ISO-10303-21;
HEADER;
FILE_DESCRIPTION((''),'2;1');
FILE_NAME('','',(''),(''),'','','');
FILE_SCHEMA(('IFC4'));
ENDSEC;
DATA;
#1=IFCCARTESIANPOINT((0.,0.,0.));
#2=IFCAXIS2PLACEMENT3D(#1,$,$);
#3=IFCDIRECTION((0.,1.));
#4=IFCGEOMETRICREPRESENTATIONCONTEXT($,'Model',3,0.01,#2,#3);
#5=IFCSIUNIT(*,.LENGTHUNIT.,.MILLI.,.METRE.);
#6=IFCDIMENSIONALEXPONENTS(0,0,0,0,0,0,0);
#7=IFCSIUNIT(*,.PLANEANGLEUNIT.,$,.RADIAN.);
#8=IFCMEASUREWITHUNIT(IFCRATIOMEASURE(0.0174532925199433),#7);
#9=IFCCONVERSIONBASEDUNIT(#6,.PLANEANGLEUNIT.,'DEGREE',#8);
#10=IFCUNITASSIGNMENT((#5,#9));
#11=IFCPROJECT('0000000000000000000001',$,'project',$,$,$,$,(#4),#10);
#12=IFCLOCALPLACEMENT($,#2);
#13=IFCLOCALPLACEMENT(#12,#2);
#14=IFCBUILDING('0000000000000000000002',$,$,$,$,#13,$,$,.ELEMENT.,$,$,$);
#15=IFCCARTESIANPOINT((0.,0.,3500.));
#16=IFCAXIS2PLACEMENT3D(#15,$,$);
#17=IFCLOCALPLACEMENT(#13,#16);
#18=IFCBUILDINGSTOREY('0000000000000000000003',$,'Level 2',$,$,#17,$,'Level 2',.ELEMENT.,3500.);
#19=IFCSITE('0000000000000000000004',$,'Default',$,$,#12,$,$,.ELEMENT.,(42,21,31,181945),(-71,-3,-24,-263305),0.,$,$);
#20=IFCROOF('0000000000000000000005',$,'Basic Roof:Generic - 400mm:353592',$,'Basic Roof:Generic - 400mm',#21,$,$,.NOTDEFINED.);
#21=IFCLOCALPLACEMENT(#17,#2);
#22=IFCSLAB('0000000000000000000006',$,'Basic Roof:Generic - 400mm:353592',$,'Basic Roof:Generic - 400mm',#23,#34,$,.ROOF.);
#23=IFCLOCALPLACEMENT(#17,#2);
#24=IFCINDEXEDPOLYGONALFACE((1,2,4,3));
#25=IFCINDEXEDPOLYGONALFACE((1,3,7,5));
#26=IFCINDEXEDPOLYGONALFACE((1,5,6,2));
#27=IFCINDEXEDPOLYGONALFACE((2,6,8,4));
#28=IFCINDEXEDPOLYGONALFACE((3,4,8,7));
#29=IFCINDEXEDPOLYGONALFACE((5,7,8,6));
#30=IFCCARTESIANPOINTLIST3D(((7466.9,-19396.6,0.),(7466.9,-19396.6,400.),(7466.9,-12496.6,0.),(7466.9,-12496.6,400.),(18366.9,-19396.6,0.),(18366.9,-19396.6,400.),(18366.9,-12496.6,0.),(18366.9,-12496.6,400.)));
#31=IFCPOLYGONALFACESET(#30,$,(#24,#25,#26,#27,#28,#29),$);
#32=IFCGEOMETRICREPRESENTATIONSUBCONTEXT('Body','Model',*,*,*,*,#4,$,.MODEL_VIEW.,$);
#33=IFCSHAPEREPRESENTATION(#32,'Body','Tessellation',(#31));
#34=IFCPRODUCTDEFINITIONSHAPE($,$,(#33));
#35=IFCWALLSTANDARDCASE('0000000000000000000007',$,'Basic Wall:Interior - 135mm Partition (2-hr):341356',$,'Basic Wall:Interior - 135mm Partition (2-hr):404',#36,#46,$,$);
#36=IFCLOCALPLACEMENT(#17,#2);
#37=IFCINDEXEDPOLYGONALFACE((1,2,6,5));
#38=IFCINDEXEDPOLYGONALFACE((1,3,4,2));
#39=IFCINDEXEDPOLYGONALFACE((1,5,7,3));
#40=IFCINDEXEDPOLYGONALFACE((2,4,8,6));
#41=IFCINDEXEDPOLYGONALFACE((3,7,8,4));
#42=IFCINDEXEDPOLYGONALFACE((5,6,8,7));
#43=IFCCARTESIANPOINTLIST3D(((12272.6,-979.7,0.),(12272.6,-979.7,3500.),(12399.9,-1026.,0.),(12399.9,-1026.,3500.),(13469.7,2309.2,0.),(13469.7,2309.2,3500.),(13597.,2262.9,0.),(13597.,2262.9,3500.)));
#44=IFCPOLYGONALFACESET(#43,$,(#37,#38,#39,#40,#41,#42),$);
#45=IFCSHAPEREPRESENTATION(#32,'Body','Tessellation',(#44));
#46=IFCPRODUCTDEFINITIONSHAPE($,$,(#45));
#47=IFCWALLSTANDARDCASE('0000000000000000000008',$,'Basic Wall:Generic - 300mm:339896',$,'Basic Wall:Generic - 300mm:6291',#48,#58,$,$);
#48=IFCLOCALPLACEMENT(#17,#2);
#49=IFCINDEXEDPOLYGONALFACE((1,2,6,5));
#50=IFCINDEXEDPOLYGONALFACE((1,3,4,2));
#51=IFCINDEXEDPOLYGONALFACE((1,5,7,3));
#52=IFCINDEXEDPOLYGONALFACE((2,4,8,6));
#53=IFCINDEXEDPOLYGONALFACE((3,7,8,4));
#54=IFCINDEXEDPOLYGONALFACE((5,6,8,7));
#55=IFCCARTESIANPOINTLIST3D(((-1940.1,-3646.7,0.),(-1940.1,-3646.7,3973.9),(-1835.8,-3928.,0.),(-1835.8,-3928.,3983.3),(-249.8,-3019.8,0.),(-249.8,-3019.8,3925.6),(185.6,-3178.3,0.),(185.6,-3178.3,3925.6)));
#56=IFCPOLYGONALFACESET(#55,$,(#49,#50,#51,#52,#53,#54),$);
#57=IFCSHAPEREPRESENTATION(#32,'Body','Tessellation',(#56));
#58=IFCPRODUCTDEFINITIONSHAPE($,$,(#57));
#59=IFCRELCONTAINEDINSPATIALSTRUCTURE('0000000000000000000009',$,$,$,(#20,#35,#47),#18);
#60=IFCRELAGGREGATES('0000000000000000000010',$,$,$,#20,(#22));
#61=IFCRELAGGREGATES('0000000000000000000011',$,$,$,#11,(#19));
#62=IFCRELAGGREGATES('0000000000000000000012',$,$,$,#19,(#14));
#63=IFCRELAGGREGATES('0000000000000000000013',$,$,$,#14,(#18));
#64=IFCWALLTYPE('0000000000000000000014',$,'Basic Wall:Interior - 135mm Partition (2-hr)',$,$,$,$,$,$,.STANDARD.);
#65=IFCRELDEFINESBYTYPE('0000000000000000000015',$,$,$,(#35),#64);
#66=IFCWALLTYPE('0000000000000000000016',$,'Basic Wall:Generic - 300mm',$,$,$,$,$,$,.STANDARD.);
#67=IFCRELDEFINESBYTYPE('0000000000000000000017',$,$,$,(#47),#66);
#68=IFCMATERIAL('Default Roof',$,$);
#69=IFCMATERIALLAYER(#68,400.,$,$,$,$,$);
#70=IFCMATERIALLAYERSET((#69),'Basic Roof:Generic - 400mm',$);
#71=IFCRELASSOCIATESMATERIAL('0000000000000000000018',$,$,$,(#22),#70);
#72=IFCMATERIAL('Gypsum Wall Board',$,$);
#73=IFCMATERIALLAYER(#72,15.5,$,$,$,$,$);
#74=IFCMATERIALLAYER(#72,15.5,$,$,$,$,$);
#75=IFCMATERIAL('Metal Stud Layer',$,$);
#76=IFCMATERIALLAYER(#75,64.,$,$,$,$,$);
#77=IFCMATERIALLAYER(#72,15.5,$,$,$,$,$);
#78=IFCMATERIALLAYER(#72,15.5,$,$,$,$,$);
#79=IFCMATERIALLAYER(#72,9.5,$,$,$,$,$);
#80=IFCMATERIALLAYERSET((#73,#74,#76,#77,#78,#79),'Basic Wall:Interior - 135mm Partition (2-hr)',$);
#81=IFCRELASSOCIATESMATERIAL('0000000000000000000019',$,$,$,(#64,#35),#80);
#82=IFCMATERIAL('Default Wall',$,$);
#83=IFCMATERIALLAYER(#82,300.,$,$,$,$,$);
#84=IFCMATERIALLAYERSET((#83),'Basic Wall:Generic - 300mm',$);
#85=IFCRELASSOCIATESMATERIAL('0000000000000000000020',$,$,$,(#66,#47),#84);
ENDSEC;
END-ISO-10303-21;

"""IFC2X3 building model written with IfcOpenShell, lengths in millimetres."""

from ifc_helpers import new_model, entity, si_unit, converted_unit, direction, frame, frame_2d, origin, place, context, subcontext, project, spatial, polyline, rectangle, outline, extrude, clip, bounded_halfspace, material, layer, layer_set, layer_usage, type_object, element, aggregate, save


model = new_model("IFC2X3")

# Units and contexts
model_context = context("Model", 3, precision=0.01, world=origin(), true_north=direction((0.0, 1.0)))
body_context = subcontext(model_context, "Body", "Model", "MODEL_VIEW")
ifc_project = project(units=[si_unit("LENGTHUNIT", "METRE", prefix="MILLI"), converted_unit("PLANEANGLEUNIT", "DEGREE", entity("IfcRatioMeasure", 0.0174532925199433), si_unit("PLANEANGLEUNIT", "RADIAN"), dimensions=[0, 0, 0, 0, 0, 0, 0])], contexts=[model_context])

# Site, building, storey
site_placement = place(None, origin())
site = spatial("IfcSite", under=ifc_project, at=site_placement, Name="Default", CompositionType="ELEMENT", RefLatitude=(42, 21, 31, 181945), RefLongitude=(-71, -3, -24, -263305), RefElevation=0.0)
building_placement = place(site_placement, origin())
building = spatial("IfcBuilding", under=site, at=building_placement, CompositionType="ELEMENT")
storey_placement = place(building_placement, frame((0.0, 0.0, 3500.0)))
storey = spatial("IfcBuildingStorey", under=building, at=storey_placement, Name="Level 2", LongName="Level 2", CompositionType="ELEMENT", Elevation=3500.0)

# Roof, slab
roof_placement = place(storey_placement, frame((7466.9, -19396.6, 0.0)))
roof = element("IfcRoof", 1, at=roof_placement, inside=storey, Name="Basic Roof:Generic - 400mm:353592", ObjectType="Basic Roof:Generic - 400mm", ShapeType="NOTDEFINED")
ifc_material_1 = material(Name="Default Roof")
ifc_layer_1 = layer(ifc_material_1, 400.0)
ifc_layer_set_1 = layer_set([ifc_layer_1], Name="Basic Roof:Generic - 400mm")
slab_placement = place(roof_placement, origin())
slab = element("IfcSlab", 2, at=slab_placement, material=ifc_layer_set_1, Name="Basic Roof:Generic - 400mm:353592", ObjectType="Basic Roof:Generic - 400mm", PredefinedType="ROOF", context=body_context, shape_type="SweptSolid", body=[
    extrude(rectangle(XDim=10900.0, YDim=6900.0, at=frame_2d((0.0, 0.0), x_axis=(1.0, 0.0))), frame((5450.0, 3450.0, 0.0)), (0.0, 0.0, 1.0), 400.0),
])
aggregate(roof, [slab])

# Wall
ifc_material_2 = material(Name="Gypsum Wall Board")
ifc_layer_2 = layer(ifc_material_2, 15.5)
ifc_layer_3 = layer(ifc_material_2, 15.5)
ifc_material_3 = material(Name="Metal Stud Layer")
ifc_layer_4 = layer(ifc_material_3, 64.0)
ifc_layer_5 = layer(ifc_material_2, 15.5)
ifc_layer_6 = layer(ifc_material_2, 15.5)
ifc_layer_7 = layer(ifc_material_2, 9.5)
ifc_layer_set_2 = layer_set([ifc_layer_2, ifc_layer_3, ifc_layer_4, ifc_layer_5, ifc_layer_6, ifc_layer_7], Name="Basic Wall:Interior - 135mm Partition (2-hr)")
ifc_layer_usage_1 = layer_usage(ifc_layer_set_2, "AXIS2", "NEGATIVE", 67.8)
wall_type_1 = type_object("IfcWallType", Name="Basic Wall:Interior - 135mm Partition (2-hr)", PredefinedType="STANDARD", material=ifc_layer_set_2)
wall_1_placement = place(storey_placement, frame((12336.3, -1002.9, 0.0), z_axis=(0.0, 0.0, 1.0), x_axis=(0.34202, 0.939693, 0.0)))
element("IfcWallStandardCase", 3, at=wall_1_placement, inside=storey, type_object=wall_type_1, material=ifc_layer_usage_1, Name="Basic Wall:Interior - 135mm Partition (2-hr):341356", ObjectType="Basic Wall:Interior - 135mm Partition (2-hr):404", context=body_context, shape_type="SweptSolid", body=[
    extrude(rectangle(XDim=3500.0, YDim=135.5, at=frame_2d((1750.0, 0.0), x_axis=(-1.0, 0.0))), origin(), (0.0, 0.0, 1.0), 3500.0),
])

# Shared definitions
ifc_material_4 = material(Name="Default Wall")
ifc_layer_8 = layer(ifc_material_4, 300.0)
ifc_layer_set_3 = layer_set([ifc_layer_8], Name="Basic Wall:Generic - 300mm")
wall_type_2 = type_object("IfcWallType", Name="Basic Wall:Generic - 300mm", PredefinedType="STANDARD", material=ifc_layer_set_3)

# Wall
ifc_layer_usage_2 = layer_usage(ifc_layer_set_3, "AXIS2", "NEGATIVE", 150.0)
wall_2_placement = place(storey_placement, frame((133.4, -3037.6, 0.0), z_axis=(0.0, 0.0, 1.0), x_axis=(-0.937589, -0.347744, 0.0)))
element("IfcWallStandardCase", 4, at=wall_2_placement, inside=storey, type_object=wall_type_2, material=ifc_layer_usage_2, Name="Basic Wall:Generic - 300mm:339896", ObjectType="Basic Wall:Generic - 300mm:6291", context=body_context, shape_type="Clipping", body=[
    clip(extrude(outline(polyline([(2156.0, -150.0), (2156.0, 150.0), (0.0, 150.0), (353.1, -150.0), (1856.0, -150.0), (2156.0, -150.0)])), origin(), (0.0, 0.0, 1.0), 3983.3), bounded_halfspace(frame((353.1, -150.0, 3925.6), z_axis=(-0.026731, -0.031465, 0.999147), x_axis=(0.76211, -0.647447, 0.0)), False, frame((353.1, -150.0, 3925.6)), polyline([(0.0, 0.0), (1502.8, 0.0), (1802.8, 0.0), (1802.8, 300.0), (-353.1, 300.0), (0.0, 0.0)]))),
])

save(model, "model.ifc")
